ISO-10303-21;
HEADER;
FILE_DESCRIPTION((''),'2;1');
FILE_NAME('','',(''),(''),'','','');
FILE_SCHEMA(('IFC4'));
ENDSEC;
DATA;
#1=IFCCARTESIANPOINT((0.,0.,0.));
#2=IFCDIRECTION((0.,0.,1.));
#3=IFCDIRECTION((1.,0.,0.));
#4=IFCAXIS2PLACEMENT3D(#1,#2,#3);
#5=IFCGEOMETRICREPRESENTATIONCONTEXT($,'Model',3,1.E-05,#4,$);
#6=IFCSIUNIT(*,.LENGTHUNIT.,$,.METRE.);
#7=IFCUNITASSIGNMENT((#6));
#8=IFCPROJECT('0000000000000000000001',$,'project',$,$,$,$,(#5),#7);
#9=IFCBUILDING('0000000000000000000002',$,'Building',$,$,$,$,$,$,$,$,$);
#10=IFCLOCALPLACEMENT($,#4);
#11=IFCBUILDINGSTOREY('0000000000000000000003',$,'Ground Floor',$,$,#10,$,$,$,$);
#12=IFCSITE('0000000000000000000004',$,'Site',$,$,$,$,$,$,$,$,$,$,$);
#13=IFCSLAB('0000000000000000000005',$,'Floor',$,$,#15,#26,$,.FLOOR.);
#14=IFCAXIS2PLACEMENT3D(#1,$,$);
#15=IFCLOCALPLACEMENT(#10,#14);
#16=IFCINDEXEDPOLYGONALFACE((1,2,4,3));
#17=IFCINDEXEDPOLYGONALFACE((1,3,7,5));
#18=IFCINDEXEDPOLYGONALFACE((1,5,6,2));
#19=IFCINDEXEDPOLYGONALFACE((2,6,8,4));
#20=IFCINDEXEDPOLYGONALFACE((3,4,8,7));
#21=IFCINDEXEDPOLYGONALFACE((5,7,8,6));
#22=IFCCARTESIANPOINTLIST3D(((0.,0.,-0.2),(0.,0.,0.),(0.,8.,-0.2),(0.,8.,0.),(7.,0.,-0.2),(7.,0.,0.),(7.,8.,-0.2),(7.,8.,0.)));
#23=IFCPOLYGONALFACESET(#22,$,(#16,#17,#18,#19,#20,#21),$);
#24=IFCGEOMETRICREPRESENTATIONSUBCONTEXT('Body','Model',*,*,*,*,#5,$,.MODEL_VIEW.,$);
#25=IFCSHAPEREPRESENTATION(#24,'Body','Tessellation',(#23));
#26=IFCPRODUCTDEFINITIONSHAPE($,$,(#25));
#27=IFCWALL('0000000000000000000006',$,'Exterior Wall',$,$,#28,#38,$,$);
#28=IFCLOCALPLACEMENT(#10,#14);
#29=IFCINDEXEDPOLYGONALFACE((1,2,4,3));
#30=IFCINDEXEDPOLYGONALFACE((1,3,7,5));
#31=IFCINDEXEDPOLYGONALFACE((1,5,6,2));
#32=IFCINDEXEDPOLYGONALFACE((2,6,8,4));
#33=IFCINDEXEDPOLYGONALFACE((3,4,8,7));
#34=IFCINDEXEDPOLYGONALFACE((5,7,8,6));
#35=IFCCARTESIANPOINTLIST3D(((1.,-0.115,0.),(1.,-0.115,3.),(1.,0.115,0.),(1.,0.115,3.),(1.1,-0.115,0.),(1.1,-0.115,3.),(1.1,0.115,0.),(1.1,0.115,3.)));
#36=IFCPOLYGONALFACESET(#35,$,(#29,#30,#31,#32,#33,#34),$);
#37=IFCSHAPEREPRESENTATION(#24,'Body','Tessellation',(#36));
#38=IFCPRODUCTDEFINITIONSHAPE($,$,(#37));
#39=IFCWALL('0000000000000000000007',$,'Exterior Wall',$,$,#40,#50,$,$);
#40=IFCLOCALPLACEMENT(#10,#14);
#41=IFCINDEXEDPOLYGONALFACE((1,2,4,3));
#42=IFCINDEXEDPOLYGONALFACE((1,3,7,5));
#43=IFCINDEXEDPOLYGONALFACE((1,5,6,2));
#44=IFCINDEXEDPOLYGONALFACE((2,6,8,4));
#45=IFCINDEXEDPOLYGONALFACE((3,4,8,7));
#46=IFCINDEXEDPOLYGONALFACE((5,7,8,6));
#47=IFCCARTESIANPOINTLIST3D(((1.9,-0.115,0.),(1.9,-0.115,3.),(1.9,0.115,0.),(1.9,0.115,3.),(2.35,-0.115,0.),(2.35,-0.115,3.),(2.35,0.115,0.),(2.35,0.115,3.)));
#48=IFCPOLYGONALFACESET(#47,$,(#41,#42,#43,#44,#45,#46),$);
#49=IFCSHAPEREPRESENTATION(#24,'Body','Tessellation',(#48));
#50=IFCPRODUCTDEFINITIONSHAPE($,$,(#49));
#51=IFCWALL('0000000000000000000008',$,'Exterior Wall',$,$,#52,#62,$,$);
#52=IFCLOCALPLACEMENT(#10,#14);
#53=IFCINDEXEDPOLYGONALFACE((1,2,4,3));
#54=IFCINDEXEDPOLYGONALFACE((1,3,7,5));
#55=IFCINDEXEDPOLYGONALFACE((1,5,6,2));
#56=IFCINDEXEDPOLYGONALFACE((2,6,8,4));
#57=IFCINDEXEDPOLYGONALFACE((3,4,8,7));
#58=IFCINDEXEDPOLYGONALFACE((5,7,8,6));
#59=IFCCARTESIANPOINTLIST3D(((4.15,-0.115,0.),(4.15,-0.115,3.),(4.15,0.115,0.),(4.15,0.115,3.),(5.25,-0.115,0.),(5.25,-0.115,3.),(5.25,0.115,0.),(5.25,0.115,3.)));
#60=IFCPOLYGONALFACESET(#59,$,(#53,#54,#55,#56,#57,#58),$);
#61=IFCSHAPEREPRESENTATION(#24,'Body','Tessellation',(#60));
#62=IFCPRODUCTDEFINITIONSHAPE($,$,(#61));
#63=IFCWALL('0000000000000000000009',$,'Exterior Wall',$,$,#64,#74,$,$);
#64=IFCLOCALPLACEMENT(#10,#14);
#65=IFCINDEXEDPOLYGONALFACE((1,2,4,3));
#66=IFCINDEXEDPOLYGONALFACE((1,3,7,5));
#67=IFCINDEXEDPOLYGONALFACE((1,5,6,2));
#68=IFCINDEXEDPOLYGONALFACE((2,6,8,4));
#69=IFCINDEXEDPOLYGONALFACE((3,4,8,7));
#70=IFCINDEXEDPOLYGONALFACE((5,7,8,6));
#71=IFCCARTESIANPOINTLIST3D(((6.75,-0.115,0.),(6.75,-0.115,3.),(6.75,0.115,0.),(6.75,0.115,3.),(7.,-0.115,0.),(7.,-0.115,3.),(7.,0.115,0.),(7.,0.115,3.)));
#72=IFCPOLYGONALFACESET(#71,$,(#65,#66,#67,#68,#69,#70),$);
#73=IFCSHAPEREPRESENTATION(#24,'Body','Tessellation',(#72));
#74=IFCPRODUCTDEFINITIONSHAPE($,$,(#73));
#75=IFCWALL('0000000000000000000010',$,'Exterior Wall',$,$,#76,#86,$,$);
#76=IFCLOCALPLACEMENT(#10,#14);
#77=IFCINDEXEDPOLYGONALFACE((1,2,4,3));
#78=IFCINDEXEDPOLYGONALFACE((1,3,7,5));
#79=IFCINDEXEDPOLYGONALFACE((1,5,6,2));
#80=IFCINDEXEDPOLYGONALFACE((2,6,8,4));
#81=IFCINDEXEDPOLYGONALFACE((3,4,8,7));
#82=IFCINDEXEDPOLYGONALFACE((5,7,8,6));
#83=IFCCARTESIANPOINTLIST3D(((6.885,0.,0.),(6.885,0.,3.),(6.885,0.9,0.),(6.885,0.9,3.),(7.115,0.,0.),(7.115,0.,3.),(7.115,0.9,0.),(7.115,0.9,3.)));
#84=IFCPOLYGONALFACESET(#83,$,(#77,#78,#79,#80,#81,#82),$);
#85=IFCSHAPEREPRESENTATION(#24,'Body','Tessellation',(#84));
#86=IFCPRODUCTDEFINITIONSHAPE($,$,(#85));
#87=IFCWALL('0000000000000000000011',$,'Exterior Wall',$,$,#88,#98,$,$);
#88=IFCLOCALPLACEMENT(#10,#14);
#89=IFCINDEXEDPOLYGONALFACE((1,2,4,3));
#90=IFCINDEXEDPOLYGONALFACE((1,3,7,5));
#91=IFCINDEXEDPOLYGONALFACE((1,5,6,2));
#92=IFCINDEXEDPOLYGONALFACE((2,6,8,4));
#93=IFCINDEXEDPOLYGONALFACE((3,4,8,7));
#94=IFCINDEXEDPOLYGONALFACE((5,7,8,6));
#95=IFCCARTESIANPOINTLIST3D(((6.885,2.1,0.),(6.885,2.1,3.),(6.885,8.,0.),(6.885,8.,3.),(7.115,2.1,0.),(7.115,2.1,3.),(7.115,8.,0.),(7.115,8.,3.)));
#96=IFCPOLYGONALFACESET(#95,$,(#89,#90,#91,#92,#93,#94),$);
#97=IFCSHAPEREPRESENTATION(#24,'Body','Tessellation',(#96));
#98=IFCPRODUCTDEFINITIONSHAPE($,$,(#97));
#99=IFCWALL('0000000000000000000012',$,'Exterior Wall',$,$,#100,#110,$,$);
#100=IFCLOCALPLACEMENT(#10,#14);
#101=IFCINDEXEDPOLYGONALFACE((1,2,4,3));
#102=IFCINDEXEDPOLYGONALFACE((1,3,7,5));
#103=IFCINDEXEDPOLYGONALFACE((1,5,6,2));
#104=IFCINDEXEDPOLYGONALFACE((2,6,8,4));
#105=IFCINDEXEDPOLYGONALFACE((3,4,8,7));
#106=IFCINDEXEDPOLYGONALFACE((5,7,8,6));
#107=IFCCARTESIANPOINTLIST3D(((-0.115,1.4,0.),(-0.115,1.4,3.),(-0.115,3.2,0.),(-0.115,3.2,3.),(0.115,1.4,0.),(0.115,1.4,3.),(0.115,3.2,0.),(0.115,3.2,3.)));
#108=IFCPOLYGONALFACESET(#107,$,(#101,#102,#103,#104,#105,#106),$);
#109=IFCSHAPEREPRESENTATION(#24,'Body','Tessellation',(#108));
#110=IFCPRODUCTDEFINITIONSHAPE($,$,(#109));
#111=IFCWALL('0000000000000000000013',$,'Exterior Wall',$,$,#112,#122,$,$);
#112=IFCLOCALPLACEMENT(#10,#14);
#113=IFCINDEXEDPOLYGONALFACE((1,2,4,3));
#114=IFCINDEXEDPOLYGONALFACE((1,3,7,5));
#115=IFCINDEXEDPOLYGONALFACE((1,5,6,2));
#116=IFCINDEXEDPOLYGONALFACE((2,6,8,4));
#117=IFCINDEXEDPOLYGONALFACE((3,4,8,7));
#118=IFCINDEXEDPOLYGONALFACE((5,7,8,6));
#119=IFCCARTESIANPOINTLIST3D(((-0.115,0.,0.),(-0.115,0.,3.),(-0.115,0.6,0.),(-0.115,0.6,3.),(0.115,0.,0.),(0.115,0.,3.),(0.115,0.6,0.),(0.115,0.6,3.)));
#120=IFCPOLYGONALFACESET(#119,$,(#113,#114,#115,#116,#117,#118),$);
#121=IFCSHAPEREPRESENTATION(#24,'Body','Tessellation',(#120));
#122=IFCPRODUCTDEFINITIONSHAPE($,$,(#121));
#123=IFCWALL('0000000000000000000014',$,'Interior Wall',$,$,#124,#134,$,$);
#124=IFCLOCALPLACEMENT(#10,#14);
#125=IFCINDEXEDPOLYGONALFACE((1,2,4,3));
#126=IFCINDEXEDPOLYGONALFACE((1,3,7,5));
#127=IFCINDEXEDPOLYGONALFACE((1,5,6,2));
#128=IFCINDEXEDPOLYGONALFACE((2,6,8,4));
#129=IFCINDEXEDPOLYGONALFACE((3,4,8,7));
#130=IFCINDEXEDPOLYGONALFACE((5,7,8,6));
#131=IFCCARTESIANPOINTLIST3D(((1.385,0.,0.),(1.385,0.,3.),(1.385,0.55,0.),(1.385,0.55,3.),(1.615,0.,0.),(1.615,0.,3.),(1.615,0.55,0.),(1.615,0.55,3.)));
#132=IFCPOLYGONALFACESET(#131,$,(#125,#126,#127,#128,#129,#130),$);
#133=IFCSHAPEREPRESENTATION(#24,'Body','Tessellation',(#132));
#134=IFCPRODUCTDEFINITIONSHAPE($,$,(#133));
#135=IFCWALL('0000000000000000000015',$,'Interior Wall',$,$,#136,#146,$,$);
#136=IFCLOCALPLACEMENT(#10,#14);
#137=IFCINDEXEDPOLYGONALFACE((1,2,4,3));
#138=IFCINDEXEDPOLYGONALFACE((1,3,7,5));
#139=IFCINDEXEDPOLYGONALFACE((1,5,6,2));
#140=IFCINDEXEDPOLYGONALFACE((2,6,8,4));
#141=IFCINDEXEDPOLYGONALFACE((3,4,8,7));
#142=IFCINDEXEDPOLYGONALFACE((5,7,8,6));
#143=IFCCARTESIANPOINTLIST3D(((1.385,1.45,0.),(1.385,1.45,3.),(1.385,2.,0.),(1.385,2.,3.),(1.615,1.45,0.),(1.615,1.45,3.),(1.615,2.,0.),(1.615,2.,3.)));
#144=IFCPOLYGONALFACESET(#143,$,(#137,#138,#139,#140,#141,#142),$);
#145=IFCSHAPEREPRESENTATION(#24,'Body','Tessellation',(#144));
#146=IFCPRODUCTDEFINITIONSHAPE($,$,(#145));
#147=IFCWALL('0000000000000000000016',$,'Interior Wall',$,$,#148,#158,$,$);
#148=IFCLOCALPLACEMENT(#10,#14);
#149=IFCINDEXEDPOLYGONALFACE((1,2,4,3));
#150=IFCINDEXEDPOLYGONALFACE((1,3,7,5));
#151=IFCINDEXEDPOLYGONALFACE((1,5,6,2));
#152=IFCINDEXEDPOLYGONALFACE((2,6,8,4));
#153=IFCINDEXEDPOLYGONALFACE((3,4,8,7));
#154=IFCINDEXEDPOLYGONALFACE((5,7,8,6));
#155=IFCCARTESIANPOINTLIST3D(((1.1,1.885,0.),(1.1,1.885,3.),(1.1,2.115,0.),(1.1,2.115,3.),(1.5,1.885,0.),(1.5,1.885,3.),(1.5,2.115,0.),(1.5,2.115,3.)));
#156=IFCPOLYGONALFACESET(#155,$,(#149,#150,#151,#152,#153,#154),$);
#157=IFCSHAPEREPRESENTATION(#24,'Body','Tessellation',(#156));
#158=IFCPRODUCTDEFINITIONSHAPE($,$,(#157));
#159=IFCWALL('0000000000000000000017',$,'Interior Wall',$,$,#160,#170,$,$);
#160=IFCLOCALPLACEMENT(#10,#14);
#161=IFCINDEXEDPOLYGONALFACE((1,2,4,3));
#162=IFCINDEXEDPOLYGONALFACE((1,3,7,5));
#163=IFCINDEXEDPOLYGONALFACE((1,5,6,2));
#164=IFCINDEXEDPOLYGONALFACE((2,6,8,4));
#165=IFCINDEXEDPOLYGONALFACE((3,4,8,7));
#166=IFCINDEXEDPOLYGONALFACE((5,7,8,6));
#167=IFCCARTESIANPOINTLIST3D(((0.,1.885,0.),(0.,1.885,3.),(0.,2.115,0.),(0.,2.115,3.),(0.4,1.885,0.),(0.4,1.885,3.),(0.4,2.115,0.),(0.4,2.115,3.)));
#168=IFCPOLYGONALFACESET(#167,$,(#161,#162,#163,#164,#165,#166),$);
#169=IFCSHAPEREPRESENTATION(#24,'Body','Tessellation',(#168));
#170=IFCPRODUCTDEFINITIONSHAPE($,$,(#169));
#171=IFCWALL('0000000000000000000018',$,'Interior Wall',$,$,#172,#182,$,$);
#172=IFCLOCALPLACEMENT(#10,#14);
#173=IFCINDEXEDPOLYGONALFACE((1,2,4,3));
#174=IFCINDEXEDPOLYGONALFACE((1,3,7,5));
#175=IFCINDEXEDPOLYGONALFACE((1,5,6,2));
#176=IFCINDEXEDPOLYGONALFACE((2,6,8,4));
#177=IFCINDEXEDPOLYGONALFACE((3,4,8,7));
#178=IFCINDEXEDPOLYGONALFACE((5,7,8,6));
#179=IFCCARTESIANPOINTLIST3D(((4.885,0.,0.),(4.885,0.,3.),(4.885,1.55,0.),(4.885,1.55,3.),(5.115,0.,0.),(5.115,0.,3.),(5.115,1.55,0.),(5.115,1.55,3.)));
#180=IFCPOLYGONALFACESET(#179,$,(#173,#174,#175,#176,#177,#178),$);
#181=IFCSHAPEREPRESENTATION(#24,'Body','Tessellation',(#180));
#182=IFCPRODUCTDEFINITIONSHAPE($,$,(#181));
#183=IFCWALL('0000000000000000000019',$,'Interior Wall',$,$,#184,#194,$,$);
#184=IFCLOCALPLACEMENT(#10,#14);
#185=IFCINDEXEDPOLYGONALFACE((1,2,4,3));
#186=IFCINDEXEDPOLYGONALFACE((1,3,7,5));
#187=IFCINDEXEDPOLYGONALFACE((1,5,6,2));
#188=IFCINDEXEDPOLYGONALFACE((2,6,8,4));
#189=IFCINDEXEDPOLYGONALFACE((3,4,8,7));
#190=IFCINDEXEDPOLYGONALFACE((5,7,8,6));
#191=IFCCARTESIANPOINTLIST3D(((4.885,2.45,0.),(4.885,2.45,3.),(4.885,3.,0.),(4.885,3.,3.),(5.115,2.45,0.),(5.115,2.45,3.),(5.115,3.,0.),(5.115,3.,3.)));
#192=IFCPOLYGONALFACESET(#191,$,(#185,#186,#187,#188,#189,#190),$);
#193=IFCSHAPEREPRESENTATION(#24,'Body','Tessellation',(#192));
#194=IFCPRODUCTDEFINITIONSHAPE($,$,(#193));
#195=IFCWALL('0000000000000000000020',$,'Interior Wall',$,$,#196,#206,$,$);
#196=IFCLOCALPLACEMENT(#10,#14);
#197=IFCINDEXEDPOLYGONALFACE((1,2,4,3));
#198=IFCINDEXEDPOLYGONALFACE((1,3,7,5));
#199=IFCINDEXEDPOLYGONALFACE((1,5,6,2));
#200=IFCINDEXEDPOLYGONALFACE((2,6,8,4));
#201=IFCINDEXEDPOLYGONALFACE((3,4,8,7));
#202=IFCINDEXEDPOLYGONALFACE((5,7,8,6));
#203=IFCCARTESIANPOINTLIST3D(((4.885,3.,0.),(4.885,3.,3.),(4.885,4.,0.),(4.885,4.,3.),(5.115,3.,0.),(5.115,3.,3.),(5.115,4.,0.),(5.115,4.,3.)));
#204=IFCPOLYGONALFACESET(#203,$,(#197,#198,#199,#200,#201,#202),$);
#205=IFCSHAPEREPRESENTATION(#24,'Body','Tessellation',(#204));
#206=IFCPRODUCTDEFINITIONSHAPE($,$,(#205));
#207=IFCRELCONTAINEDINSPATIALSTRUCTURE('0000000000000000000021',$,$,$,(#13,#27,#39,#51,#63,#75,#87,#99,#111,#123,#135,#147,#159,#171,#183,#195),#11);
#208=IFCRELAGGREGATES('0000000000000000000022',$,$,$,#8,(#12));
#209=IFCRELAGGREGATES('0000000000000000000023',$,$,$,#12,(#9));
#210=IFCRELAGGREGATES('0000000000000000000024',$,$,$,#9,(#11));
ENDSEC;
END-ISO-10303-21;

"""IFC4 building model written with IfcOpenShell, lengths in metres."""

from ifc_helpers import new_model, si_unit, frame, origin_with_axes, place, context, subcontext, project, spatial, indexed_curve, outline, extrude, element, save


model = new_model("IFC4")

# Units and contexts
model_context = context("Model", 3, precision=1e-05, world=origin_with_axes())
body_context = subcontext(model_context, "Body", "Model", "MODEL_VIEW")
ifc_project = project(units=[si_unit("LENGTHUNIT", "METRE")], contexts=[model_context])

# Site, building, storey
site = spatial("IfcSite", under=ifc_project, Name="Site")
building = spatial("IfcBuilding", under=site, Name="Building")
storey_placement = place(None, origin_with_axes())
storey = spatial("IfcBuildingStorey", under=building, at=storey_placement, Name="Ground Floor")

# Slab
slab_placement = place(storey_placement, frame((0.0, 0.0, -0.2), z_axis=(0.0, 0.0, 1.0), x_axis=(1.0, 0.0, 0.0)))
element("IfcSlab", 1, at=slab_placement, inside=storey, Name="Floor", PredefinedType="FLOOR", context=body_context, shape_type="SweptSolid", body=[
    extrude(outline(indexed_curve([(0.0, 0.0), (7.0, 0.0), (7.0, 8.0), (0.0, 8.0)])), None, (0.0, 0.0, 1.0), 0.2),
])

# Walls
wall_1_placement = place(storey_placement, frame((1.0, 0.0, 0.0), z_axis=(0.0, 0.0, 1.0), x_axis=(1.0, 0.0, 0.0)))
element("IfcWall", 2, at=wall_1_placement, inside=storey, Name="Exterior Wall", context=body_context, shape_type="SweptSolid", body=[
    extrude(outline(indexed_curve([(0.0, 0.0), (0.0, 0.23), (0.1, 0.23), (0.1, 0.0), (0.0, 0.0)], self_intersect=False)), frame((0.0, -0.115, 0.0), z_axis=(0.0, 0.0, 1.0), x_axis=(1.0, 0.0, 0.0)), (0.0, 0.0, 1.0), 3.0),
])
wall_2_placement = place(storey_placement, frame((1.9, 0.0, 0.0), z_axis=(0.0, 0.0, 1.0), x_axis=(1.0, 0.0, 0.0)))
element("IfcWall", 3, at=wall_2_placement, inside=storey, Name="Exterior Wall", context=body_context, shape_type="SweptSolid", body=[
    extrude(outline(indexed_curve([(0.0, 0.0), (0.0, 0.23), (0.45, 0.23), (0.45, 0.0), (0.0, 0.0)], self_intersect=False)), frame((0.0, -0.115, 0.0), z_axis=(0.0, 0.0, 1.0), x_axis=(1.0, 0.0, 0.0)), (0.0, 0.0, 1.0), 3.0),
])
wall_3_placement = place(storey_placement, frame((4.15, 0.0, 0.0), z_axis=(0.0, 0.0, 1.0), x_axis=(1.0, 0.0, 0.0)))
element("IfcWall", 4, at=wall_3_placement, inside=storey, Name="Exterior Wall", context=body_context, shape_type="SweptSolid", body=[
    extrude(outline(indexed_curve([(0.0, 0.0), (0.0, 0.23), (1.1, 0.23), (1.1, 0.0), (0.0, 0.0)], self_intersect=False)), frame((0.0, -0.115, 0.0), z_axis=(0.0, 0.0, 1.0), x_axis=(1.0, 0.0, 0.0)), (0.0, 0.0, 1.0), 3.0),
])
wall_4_placement = place(storey_placement, frame((6.75, 0.0, 0.0), z_axis=(0.0, 0.0, 1.0), x_axis=(1.0, 0.0, 0.0)))
element("IfcWall", 5, at=wall_4_placement, inside=storey, Name="Exterior Wall", context=body_context, shape_type="SweptSolid", body=[
    extrude(outline(indexed_curve([(0.0, 0.0), (0.0, 0.23), (0.25, 0.23), (0.25, 0.0), (0.0, 0.0)], self_intersect=False)), frame((0.0, -0.115, 0.0), z_axis=(0.0, 0.0, 1.0), x_axis=(1.0, 0.0, 0.0)), (0.0, 0.0, 1.0), 3.0),
])
wall_5_placement = place(storey_placement, frame((7.0, 0.0, 0.0), z_axis=(0.0, 0.0, 1.0), x_axis=(0.0, 1.0, 0.0)))
element("IfcWall", 6, at=wall_5_placement, inside=storey, Name="Exterior Wall", context=body_context, shape_type="SweptSolid", body=[
    extrude(outline(indexed_curve([(0.0, 0.0), (0.0, 0.23), (0.9, 0.23), (0.9, 0.0), (0.0, 0.0)], self_intersect=False)), frame((0.0, -0.115, 0.0), z_axis=(0.0, 0.0, 1.0), x_axis=(1.0, 0.0, 0.0)), (0.0, 0.0, 1.0), 3.0),
])
wall_6_placement = place(storey_placement, frame((7.0, 2.1, 0.0), z_axis=(0.0, 0.0, 1.0), x_axis=(0.0, 1.0, 0.0)))
element("IfcWall", 7, at=wall_6_placement, inside=storey, Name="Exterior Wall", context=body_context, shape_type="SweptSolid", body=[
    extrude(outline(indexed_curve([(0.0, 0.0), (0.0, 0.23), (5.9, 0.23), (5.9, 0.0), (0.0, 0.0)], self_intersect=False)), frame((0.0, -0.115, 0.0), z_axis=(0.0, 0.0, 1.0), x_axis=(1.0, 0.0, 0.0)), (0.0, 0.0, 1.0), 3.0),
])
wall_7_placement = place(storey_placement, frame((0.0, 3.2, 0.0), z_axis=(0.0, 0.0, 1.0), x_axis=(0.0, -1.0, 0.0)))
element("IfcWall", 8, at=wall_7_placement, inside=storey, Name="Exterior Wall", context=body_context, shape_type="SweptSolid", body=[
    extrude(outline(indexed_curve([(0.0, 0.0), (0.0, 0.23), (1.8, 0.23), (1.8, 0.0), (0.0, 0.0)], self_intersect=False)), frame((0.0, -0.115, 0.0), z_axis=(0.0, 0.0, 1.0), x_axis=(1.0, 0.0, 0.0)), (0.0, 0.0, 1.0), 3.0),
])
wall_8_placement = place(storey_placement, frame((0.0, 0.6, 0.0), z_axis=(0.0, 0.0, 1.0), x_axis=(0.0, -1.0, 0.0)))
element("IfcWall", 9, at=wall_8_placement, inside=storey, Name="Exterior Wall", context=body_context, shape_type="SweptSolid", body=[
    extrude(outline(indexed_curve([(0.0, 0.0), (0.0, 0.23), (0.6, 0.23), (0.6, 0.0), (0.0, 0.0)], self_intersect=False)), frame((0.0, -0.115, 0.0), z_axis=(0.0, 0.0, 1.0), x_axis=(1.0, 0.0, 0.0)), (0.0, 0.0, 1.0), 3.0),
])
for number, where, z_axis, x_axis, name in (
    (10, (1.5, 0.0, 0.0), (0.0, 0.0, 1.0), (0.0, 1.0, 0.0), "Interior Wall"),
    (11, (1.5, 1.45, 0.0), (0.0, 0.0, 1.0), (0.0, 1.0, 0.0), "Interior Wall"),
):
    element("IfcWall", number, at=place(storey_placement, frame(where, z_axis=z_axis, x_axis=x_axis)), inside=storey, Name=name, context=body_context, shape_type="SweptSolid", body=[
        extrude(outline(indexed_curve([(0.0, 0.0), (0.0, 0.23), (0.55, 0.23), (0.55, 0.0), (0.0, 0.0)], self_intersect=False)), frame((0.0, -0.115, 0.0), z_axis=(0.0, 0.0, 1.0), x_axis=(1.0, 0.0, 0.0)), (0.0, 0.0, 1.0), 3.0),
    ])
for number, where, z_axis, x_axis, name in (
    (12, (1.5, 2.0, 0.0), (0.0, 0.0, 1.0), (-1.0, 0.0, 0.0), "Interior Wall"),
    (13, (0.4, 2.0, 0.0), (0.0, 0.0, 1.0), (-1.0, 0.0, 0.0), "Interior Wall"),
):
    element("IfcWall", number, at=place(storey_placement, frame(where, z_axis=z_axis, x_axis=x_axis)), inside=storey, Name=name, context=body_context, shape_type="SweptSolid", body=[
        extrude(outline(indexed_curve([(0.0, 0.0), (0.0, 0.23), (0.4, 0.23), (0.4, 0.0), (0.0, 0.0)], self_intersect=False)), frame((0.0, -0.115, 0.0), z_axis=(0.0, 0.0, 1.0), x_axis=(1.0, 0.0, 0.0)), (0.0, 0.0, 1.0), 3.0),
    ])
wall_9_placement = place(storey_placement, frame((5.0, 0.0, 0.0), z_axis=(0.0, 0.0, 1.0), x_axis=(0.0, 1.0, 0.0)))
element("IfcWall", 14, at=wall_9_placement, inside=storey, Name="Interior Wall", context=body_context, shape_type="SweptSolid", body=[
    extrude(outline(indexed_curve([(0.0, 0.0), (0.0, 0.23), (1.55, 0.23), (1.55, 0.0), (0.0, 0.0)], self_intersect=False)), frame((0.0, -0.115, 0.0), z_axis=(0.0, 0.0, 1.0), x_axis=(1.0, 0.0, 0.0)), (0.0, 0.0, 1.0), 3.0),
])
wall_10_placement = place(storey_placement, frame((5.0, 2.45, 0.0), z_axis=(0.0, 0.0, 1.0), x_axis=(0.0, 1.0, 0.0)))
element("IfcWall", 15, at=wall_10_placement, inside=storey, Name="Interior Wall", context=body_context, shape_type="SweptSolid", body=[
    extrude(outline(indexed_curve([(0.0, 0.0), (0.0, 0.23), (0.55, 0.23), (0.55, 0.0), (0.0, 0.0)], self_intersect=False)), frame((0.0, -0.115, 0.0), z_axis=(0.0, 0.0, 1.0), x_axis=(1.0, 0.0, 0.0)), (0.0, 0.0, 1.0), 3.0),
])
wall_11_placement = place(storey_placement, frame((5.0, 3.0, 0.0), z_axis=(0.0, 0.0, 1.0), x_axis=(0.0, 1.0, 0.0)))
element("IfcWall", 16, at=wall_11_placement, inside=storey, Name="Interior Wall", context=body_context, shape_type="SweptSolid", body=[
    extrude(outline(indexed_curve([(0.0, 0.0), (0.0, 0.23), (1.0, 0.23), (1.0, 0.0), (0.0, 0.0)], self_intersect=False)), frame((0.0, -0.115, 0.0), z_axis=(0.0, 0.0, 1.0), x_axis=(1.0, 0.0, 0.0)), (0.0, 0.0, 1.0), 3.0),
])

save(model, "model.ifc")
